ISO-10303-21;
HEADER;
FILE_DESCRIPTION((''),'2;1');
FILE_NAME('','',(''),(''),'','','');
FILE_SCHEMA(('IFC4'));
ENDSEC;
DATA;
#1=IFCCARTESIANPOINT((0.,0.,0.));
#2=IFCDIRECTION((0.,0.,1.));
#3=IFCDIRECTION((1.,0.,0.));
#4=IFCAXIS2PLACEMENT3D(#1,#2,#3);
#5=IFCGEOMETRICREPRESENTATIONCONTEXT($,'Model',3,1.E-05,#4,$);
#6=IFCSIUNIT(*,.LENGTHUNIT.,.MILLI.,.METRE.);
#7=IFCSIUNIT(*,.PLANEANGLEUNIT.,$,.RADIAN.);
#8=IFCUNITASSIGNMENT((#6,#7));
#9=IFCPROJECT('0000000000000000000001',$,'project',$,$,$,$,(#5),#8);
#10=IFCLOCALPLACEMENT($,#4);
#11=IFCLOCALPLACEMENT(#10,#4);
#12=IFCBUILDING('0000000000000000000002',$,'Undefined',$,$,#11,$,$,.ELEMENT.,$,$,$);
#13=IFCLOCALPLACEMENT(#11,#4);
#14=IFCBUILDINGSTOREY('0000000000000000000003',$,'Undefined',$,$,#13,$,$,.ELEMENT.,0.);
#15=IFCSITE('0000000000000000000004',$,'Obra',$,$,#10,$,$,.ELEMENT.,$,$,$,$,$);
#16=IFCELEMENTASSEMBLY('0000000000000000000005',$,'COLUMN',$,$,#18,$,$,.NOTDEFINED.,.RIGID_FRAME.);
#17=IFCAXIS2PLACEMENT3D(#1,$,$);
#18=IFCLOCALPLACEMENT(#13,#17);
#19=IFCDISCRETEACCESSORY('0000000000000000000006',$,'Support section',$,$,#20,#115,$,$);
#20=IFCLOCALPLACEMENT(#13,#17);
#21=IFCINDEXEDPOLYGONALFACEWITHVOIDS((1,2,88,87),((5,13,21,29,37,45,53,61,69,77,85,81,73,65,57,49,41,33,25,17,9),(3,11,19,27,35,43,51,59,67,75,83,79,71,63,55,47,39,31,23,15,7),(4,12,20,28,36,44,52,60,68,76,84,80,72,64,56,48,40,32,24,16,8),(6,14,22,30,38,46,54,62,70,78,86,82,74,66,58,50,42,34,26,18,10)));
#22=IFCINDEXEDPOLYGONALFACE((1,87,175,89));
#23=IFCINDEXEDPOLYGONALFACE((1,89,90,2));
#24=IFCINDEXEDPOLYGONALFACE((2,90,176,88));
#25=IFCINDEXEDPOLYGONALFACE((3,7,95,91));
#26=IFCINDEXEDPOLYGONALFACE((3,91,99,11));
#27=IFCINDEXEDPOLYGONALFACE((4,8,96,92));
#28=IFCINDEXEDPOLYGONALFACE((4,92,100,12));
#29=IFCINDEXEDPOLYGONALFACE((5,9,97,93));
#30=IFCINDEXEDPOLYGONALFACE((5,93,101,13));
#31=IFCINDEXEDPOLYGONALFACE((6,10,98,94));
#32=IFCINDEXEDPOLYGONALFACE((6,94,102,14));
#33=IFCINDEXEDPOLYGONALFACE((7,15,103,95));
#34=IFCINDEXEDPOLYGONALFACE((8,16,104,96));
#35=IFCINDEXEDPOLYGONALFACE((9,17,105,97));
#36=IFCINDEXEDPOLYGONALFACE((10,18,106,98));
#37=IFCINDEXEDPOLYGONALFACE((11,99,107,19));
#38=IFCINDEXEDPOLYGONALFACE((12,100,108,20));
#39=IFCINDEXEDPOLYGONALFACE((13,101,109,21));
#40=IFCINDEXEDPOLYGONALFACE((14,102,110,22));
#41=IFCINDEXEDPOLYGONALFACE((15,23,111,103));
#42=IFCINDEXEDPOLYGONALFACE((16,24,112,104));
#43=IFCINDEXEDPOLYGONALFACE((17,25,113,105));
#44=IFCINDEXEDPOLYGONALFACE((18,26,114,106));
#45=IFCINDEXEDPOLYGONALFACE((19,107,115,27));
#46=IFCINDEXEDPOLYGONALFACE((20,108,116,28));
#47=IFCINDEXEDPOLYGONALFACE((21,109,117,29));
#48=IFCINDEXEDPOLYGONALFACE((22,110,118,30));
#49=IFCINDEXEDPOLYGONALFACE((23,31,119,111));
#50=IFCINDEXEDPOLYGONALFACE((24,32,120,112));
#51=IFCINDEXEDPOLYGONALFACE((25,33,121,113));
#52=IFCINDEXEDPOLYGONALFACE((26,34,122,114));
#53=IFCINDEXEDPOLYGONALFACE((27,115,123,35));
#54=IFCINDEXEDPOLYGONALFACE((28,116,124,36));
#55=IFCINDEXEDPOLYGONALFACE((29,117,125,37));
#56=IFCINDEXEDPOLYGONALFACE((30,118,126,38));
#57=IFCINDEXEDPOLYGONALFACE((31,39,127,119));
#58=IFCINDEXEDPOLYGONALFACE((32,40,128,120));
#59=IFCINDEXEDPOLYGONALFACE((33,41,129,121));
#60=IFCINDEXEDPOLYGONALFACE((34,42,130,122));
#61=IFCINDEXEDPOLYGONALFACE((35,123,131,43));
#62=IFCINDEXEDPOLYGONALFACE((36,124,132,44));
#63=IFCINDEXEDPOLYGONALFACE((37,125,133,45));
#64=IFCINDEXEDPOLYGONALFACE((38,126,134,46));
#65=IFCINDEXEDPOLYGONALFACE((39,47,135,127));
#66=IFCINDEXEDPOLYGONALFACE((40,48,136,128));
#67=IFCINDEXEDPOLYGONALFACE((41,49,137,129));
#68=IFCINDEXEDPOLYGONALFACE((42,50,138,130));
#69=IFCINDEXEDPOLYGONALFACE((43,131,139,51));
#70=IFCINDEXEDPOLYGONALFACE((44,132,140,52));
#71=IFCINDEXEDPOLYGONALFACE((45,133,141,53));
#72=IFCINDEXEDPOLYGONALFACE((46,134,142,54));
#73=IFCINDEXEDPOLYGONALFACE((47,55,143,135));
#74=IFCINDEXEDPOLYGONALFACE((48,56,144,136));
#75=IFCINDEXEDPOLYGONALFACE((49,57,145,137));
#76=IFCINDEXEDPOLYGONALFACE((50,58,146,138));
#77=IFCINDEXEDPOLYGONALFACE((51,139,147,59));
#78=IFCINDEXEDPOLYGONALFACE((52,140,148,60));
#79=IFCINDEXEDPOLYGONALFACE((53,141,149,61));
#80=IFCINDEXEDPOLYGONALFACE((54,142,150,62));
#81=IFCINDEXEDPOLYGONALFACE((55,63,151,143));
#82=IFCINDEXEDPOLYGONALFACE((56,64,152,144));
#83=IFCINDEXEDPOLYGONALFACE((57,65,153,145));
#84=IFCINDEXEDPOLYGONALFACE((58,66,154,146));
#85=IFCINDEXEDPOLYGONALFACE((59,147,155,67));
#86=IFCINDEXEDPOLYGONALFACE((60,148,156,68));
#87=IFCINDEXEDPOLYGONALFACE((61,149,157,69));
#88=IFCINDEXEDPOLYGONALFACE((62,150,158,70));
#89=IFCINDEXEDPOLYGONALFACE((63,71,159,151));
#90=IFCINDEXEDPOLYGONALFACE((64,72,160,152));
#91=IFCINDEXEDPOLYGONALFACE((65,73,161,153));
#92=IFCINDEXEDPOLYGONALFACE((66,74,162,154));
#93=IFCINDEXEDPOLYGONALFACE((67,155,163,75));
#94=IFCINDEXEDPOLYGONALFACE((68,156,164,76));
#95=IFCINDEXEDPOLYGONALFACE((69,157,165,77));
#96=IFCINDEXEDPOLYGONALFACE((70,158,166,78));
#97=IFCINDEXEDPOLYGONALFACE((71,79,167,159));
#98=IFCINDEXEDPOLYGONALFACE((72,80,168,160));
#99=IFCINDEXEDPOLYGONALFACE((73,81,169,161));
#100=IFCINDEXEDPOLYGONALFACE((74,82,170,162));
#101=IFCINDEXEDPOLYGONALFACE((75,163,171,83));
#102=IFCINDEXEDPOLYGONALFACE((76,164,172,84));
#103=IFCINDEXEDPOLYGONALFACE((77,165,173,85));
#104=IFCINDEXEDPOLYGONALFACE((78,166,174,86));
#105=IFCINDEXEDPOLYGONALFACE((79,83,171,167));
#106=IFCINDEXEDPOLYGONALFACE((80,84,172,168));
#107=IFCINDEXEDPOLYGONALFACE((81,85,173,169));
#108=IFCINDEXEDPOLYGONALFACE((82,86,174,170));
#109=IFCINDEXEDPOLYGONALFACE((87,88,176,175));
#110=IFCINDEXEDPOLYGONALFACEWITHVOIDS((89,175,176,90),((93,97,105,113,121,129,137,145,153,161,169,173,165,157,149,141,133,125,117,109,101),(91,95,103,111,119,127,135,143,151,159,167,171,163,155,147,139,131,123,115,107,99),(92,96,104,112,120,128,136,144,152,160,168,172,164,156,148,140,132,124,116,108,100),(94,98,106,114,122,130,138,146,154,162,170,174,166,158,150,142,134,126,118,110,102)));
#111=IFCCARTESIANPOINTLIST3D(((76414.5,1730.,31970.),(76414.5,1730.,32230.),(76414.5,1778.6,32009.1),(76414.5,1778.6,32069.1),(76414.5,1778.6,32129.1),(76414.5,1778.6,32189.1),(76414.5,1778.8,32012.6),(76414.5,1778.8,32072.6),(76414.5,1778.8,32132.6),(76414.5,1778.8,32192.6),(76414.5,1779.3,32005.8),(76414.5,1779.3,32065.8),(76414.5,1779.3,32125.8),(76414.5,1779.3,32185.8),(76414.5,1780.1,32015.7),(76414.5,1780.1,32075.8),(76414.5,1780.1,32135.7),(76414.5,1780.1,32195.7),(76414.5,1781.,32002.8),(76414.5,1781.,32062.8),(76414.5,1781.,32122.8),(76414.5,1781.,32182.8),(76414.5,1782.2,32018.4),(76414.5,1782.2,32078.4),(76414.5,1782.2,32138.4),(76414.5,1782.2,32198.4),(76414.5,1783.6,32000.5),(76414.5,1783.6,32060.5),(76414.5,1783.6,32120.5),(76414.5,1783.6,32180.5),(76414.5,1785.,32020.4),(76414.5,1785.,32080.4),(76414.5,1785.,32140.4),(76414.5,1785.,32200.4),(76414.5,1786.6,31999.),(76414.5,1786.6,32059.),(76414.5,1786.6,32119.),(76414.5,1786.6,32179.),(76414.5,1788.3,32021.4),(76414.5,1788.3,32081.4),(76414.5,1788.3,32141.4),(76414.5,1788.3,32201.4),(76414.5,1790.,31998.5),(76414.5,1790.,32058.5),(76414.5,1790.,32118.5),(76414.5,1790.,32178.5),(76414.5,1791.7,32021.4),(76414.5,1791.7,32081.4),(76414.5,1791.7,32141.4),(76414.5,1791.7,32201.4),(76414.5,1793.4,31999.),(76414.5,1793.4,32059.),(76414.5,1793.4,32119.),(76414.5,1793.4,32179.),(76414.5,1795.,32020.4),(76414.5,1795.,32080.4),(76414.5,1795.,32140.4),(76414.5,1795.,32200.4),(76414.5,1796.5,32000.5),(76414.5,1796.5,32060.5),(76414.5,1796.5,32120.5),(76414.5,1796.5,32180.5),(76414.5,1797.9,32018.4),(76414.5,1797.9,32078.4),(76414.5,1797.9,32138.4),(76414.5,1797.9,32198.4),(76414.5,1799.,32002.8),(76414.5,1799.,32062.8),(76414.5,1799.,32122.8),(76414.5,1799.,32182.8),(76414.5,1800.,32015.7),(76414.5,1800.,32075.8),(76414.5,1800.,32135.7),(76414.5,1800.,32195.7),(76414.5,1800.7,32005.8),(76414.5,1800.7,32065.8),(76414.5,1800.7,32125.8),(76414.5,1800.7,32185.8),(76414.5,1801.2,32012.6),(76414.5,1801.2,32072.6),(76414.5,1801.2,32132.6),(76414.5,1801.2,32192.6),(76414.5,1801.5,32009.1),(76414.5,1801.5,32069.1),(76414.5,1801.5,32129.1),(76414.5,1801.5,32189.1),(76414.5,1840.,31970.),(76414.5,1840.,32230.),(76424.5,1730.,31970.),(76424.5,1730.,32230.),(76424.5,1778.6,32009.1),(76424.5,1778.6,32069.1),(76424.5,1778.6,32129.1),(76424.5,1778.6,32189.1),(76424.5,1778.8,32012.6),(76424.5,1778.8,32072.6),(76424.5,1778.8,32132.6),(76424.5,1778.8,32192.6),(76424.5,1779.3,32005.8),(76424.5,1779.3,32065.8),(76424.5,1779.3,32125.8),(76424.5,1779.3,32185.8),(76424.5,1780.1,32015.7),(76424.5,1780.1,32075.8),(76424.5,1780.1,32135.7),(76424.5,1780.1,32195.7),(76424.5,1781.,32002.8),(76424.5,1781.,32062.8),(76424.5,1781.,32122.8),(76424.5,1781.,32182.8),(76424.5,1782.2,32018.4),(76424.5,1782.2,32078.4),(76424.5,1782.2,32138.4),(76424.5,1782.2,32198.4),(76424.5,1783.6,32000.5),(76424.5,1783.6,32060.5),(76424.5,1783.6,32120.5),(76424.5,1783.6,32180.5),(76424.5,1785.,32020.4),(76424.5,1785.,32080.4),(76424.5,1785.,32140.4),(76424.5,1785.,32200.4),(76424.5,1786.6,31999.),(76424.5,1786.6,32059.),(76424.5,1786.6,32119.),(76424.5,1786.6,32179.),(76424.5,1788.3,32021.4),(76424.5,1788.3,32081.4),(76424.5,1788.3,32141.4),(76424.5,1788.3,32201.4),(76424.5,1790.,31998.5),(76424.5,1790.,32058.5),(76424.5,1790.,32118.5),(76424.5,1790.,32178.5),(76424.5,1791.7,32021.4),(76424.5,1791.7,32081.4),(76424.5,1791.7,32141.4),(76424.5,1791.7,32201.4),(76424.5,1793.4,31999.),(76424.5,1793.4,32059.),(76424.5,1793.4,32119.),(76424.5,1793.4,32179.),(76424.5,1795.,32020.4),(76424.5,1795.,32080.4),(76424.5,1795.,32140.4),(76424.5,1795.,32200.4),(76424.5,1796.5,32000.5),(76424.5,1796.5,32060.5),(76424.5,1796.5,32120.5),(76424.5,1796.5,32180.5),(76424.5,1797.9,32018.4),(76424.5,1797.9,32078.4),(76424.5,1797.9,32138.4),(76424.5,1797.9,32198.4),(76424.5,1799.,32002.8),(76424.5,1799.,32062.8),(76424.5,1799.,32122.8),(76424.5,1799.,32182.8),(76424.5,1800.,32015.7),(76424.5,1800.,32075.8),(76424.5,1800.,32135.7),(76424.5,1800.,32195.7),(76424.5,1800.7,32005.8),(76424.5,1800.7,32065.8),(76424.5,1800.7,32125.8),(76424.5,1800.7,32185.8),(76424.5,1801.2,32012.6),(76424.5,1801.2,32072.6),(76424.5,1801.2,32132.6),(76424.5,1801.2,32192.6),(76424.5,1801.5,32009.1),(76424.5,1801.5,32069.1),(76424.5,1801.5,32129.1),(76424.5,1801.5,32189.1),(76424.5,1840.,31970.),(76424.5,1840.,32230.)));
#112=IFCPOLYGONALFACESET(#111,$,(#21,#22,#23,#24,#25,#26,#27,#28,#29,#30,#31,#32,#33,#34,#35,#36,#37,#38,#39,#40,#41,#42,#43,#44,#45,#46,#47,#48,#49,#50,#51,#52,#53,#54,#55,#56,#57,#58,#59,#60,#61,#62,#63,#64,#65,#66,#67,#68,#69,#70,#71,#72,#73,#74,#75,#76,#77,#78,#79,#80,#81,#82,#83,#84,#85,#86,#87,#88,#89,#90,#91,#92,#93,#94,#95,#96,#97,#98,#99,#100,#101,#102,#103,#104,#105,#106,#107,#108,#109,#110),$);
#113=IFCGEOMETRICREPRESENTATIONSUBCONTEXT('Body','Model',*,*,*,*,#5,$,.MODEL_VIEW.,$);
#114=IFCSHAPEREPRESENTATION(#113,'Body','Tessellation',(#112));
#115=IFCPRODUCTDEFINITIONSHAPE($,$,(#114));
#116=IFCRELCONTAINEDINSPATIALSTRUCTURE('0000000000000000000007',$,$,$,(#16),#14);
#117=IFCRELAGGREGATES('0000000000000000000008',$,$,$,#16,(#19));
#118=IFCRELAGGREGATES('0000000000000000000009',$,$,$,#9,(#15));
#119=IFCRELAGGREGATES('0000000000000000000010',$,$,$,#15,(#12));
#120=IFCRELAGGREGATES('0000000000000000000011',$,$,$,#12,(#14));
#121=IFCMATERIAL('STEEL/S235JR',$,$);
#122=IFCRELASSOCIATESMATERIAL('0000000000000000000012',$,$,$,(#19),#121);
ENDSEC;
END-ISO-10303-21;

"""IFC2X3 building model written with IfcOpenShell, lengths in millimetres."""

from ifc_helpers import new_model, si_unit, frame, origin_with_axes, origin_2d_with_axis, place, context, subcontext, project, spatial, rectangle, circle, extrude, source, transform, mapped, material, element, aggregate, save


model = new_model("IFC2X3")

# Units and contexts
model_context = context("Model", 3, precision=1e-05, world=origin_with_axes())
body_context = subcontext(model_context, "Body", "Model", "MODEL_VIEW")
ifc_project = project(units=[si_unit("LENGTHUNIT", "METRE", prefix="MILLI"), si_unit("PLANEANGLEUNIT", "RADIAN")], contexts=[model_context])

# Site, building, storey
site_placement = place(None, origin_with_axes())
site = spatial("IfcSite", under=ifc_project, at=site_placement, Name="Obra", CompositionType="ELEMENT")
building_placement = place(site_placement, origin_with_axes())
building = spatial("IfcBuilding", under=site, at=building_placement, Name="Undefined", CompositionType="ELEMENT")
storey_placement = place(building_placement, origin_with_axes())
storey = spatial("IfcBuildingStorey", under=building, at=storey_placement, Name="Undefined", CompositionType="ELEMENT", Elevation=0.0)

# Shared definitions
ifc_material_1 = material(Name="STEEL/S235JR")

# Element assembly, discrete accessory, opening
shared_shape_1 = source(origin_with_axes(), body_context, "Body", "SweptSolid", [
    extrude(circle(Radius=11.5, at=origin_2d_with_axis()), frame((0.0, -14.4, 0.0), z_axis=(0.0, 1.0, 0.0), x_axis=(1.0, 0.0, 0.0)), (0.0, 0.0, 1.0), 10.2),
])
assembly_1_placement = place(storey_placement, origin_with_axes())
assembly_1 = element("IfcElementAssembly", 1, at=assembly_1_placement, inside=storey, Name="COLUMN", AssemblyPlace="NOTDEFINED", PredefinedType="RIGID_FRAME")
discrete_accessory_1_placement = place(assembly_1_placement, frame((76419.5, 1785.0, 31970.0), z_axis=(0.0, 0.0, 1.0), x_axis=(0.0, -1.0, 0.0)))
discrete_accessory_1 = element("IfcDiscreteAccessory", 2, at=discrete_accessory_1_placement, material=ifc_material_1, Name="Support section", context=body_context, shape_type="SweptSolid", body=[
    extrude(rectangle(XDim=10.0, YDim=110.0, at=origin_2d_with_axis()), frame((0.0, 0.0, 260.0), z_axis=(0.0, 0.0, -1.0), x_axis=(0.0, 1.0, 0.0)), (0.0, 0.0, 1.0), 260.0),
])
opening_1_placement = place(assembly_1_placement, frame((76410.2, 1740.0, 32300.0), z_axis=(0.0, 1.0, 0.0), x_axis=(0.0, 0.0, -1.0)))
element("IfcOpeningElement", 3, at=opening_1_placement, cuts=discrete_accessory_1, ObjectType="Opening", context=body_context, shape_type="MappedRepresentation", body=[
    mapped(shared_shape_1, transform((110.0, 0.0, 50.0))),
    mapped(shared_shape_1, transform((170.0, 0.0, 50.0))),
    mapped(shared_shape_1, transform((230.0, 0.0, 50.0))),
    mapped(shared_shape_1, transform((290.0, 0.0, 50.0))),
])
aggregate(assembly_1, [discrete_accessory_1])

save(model, "model.ifc")
